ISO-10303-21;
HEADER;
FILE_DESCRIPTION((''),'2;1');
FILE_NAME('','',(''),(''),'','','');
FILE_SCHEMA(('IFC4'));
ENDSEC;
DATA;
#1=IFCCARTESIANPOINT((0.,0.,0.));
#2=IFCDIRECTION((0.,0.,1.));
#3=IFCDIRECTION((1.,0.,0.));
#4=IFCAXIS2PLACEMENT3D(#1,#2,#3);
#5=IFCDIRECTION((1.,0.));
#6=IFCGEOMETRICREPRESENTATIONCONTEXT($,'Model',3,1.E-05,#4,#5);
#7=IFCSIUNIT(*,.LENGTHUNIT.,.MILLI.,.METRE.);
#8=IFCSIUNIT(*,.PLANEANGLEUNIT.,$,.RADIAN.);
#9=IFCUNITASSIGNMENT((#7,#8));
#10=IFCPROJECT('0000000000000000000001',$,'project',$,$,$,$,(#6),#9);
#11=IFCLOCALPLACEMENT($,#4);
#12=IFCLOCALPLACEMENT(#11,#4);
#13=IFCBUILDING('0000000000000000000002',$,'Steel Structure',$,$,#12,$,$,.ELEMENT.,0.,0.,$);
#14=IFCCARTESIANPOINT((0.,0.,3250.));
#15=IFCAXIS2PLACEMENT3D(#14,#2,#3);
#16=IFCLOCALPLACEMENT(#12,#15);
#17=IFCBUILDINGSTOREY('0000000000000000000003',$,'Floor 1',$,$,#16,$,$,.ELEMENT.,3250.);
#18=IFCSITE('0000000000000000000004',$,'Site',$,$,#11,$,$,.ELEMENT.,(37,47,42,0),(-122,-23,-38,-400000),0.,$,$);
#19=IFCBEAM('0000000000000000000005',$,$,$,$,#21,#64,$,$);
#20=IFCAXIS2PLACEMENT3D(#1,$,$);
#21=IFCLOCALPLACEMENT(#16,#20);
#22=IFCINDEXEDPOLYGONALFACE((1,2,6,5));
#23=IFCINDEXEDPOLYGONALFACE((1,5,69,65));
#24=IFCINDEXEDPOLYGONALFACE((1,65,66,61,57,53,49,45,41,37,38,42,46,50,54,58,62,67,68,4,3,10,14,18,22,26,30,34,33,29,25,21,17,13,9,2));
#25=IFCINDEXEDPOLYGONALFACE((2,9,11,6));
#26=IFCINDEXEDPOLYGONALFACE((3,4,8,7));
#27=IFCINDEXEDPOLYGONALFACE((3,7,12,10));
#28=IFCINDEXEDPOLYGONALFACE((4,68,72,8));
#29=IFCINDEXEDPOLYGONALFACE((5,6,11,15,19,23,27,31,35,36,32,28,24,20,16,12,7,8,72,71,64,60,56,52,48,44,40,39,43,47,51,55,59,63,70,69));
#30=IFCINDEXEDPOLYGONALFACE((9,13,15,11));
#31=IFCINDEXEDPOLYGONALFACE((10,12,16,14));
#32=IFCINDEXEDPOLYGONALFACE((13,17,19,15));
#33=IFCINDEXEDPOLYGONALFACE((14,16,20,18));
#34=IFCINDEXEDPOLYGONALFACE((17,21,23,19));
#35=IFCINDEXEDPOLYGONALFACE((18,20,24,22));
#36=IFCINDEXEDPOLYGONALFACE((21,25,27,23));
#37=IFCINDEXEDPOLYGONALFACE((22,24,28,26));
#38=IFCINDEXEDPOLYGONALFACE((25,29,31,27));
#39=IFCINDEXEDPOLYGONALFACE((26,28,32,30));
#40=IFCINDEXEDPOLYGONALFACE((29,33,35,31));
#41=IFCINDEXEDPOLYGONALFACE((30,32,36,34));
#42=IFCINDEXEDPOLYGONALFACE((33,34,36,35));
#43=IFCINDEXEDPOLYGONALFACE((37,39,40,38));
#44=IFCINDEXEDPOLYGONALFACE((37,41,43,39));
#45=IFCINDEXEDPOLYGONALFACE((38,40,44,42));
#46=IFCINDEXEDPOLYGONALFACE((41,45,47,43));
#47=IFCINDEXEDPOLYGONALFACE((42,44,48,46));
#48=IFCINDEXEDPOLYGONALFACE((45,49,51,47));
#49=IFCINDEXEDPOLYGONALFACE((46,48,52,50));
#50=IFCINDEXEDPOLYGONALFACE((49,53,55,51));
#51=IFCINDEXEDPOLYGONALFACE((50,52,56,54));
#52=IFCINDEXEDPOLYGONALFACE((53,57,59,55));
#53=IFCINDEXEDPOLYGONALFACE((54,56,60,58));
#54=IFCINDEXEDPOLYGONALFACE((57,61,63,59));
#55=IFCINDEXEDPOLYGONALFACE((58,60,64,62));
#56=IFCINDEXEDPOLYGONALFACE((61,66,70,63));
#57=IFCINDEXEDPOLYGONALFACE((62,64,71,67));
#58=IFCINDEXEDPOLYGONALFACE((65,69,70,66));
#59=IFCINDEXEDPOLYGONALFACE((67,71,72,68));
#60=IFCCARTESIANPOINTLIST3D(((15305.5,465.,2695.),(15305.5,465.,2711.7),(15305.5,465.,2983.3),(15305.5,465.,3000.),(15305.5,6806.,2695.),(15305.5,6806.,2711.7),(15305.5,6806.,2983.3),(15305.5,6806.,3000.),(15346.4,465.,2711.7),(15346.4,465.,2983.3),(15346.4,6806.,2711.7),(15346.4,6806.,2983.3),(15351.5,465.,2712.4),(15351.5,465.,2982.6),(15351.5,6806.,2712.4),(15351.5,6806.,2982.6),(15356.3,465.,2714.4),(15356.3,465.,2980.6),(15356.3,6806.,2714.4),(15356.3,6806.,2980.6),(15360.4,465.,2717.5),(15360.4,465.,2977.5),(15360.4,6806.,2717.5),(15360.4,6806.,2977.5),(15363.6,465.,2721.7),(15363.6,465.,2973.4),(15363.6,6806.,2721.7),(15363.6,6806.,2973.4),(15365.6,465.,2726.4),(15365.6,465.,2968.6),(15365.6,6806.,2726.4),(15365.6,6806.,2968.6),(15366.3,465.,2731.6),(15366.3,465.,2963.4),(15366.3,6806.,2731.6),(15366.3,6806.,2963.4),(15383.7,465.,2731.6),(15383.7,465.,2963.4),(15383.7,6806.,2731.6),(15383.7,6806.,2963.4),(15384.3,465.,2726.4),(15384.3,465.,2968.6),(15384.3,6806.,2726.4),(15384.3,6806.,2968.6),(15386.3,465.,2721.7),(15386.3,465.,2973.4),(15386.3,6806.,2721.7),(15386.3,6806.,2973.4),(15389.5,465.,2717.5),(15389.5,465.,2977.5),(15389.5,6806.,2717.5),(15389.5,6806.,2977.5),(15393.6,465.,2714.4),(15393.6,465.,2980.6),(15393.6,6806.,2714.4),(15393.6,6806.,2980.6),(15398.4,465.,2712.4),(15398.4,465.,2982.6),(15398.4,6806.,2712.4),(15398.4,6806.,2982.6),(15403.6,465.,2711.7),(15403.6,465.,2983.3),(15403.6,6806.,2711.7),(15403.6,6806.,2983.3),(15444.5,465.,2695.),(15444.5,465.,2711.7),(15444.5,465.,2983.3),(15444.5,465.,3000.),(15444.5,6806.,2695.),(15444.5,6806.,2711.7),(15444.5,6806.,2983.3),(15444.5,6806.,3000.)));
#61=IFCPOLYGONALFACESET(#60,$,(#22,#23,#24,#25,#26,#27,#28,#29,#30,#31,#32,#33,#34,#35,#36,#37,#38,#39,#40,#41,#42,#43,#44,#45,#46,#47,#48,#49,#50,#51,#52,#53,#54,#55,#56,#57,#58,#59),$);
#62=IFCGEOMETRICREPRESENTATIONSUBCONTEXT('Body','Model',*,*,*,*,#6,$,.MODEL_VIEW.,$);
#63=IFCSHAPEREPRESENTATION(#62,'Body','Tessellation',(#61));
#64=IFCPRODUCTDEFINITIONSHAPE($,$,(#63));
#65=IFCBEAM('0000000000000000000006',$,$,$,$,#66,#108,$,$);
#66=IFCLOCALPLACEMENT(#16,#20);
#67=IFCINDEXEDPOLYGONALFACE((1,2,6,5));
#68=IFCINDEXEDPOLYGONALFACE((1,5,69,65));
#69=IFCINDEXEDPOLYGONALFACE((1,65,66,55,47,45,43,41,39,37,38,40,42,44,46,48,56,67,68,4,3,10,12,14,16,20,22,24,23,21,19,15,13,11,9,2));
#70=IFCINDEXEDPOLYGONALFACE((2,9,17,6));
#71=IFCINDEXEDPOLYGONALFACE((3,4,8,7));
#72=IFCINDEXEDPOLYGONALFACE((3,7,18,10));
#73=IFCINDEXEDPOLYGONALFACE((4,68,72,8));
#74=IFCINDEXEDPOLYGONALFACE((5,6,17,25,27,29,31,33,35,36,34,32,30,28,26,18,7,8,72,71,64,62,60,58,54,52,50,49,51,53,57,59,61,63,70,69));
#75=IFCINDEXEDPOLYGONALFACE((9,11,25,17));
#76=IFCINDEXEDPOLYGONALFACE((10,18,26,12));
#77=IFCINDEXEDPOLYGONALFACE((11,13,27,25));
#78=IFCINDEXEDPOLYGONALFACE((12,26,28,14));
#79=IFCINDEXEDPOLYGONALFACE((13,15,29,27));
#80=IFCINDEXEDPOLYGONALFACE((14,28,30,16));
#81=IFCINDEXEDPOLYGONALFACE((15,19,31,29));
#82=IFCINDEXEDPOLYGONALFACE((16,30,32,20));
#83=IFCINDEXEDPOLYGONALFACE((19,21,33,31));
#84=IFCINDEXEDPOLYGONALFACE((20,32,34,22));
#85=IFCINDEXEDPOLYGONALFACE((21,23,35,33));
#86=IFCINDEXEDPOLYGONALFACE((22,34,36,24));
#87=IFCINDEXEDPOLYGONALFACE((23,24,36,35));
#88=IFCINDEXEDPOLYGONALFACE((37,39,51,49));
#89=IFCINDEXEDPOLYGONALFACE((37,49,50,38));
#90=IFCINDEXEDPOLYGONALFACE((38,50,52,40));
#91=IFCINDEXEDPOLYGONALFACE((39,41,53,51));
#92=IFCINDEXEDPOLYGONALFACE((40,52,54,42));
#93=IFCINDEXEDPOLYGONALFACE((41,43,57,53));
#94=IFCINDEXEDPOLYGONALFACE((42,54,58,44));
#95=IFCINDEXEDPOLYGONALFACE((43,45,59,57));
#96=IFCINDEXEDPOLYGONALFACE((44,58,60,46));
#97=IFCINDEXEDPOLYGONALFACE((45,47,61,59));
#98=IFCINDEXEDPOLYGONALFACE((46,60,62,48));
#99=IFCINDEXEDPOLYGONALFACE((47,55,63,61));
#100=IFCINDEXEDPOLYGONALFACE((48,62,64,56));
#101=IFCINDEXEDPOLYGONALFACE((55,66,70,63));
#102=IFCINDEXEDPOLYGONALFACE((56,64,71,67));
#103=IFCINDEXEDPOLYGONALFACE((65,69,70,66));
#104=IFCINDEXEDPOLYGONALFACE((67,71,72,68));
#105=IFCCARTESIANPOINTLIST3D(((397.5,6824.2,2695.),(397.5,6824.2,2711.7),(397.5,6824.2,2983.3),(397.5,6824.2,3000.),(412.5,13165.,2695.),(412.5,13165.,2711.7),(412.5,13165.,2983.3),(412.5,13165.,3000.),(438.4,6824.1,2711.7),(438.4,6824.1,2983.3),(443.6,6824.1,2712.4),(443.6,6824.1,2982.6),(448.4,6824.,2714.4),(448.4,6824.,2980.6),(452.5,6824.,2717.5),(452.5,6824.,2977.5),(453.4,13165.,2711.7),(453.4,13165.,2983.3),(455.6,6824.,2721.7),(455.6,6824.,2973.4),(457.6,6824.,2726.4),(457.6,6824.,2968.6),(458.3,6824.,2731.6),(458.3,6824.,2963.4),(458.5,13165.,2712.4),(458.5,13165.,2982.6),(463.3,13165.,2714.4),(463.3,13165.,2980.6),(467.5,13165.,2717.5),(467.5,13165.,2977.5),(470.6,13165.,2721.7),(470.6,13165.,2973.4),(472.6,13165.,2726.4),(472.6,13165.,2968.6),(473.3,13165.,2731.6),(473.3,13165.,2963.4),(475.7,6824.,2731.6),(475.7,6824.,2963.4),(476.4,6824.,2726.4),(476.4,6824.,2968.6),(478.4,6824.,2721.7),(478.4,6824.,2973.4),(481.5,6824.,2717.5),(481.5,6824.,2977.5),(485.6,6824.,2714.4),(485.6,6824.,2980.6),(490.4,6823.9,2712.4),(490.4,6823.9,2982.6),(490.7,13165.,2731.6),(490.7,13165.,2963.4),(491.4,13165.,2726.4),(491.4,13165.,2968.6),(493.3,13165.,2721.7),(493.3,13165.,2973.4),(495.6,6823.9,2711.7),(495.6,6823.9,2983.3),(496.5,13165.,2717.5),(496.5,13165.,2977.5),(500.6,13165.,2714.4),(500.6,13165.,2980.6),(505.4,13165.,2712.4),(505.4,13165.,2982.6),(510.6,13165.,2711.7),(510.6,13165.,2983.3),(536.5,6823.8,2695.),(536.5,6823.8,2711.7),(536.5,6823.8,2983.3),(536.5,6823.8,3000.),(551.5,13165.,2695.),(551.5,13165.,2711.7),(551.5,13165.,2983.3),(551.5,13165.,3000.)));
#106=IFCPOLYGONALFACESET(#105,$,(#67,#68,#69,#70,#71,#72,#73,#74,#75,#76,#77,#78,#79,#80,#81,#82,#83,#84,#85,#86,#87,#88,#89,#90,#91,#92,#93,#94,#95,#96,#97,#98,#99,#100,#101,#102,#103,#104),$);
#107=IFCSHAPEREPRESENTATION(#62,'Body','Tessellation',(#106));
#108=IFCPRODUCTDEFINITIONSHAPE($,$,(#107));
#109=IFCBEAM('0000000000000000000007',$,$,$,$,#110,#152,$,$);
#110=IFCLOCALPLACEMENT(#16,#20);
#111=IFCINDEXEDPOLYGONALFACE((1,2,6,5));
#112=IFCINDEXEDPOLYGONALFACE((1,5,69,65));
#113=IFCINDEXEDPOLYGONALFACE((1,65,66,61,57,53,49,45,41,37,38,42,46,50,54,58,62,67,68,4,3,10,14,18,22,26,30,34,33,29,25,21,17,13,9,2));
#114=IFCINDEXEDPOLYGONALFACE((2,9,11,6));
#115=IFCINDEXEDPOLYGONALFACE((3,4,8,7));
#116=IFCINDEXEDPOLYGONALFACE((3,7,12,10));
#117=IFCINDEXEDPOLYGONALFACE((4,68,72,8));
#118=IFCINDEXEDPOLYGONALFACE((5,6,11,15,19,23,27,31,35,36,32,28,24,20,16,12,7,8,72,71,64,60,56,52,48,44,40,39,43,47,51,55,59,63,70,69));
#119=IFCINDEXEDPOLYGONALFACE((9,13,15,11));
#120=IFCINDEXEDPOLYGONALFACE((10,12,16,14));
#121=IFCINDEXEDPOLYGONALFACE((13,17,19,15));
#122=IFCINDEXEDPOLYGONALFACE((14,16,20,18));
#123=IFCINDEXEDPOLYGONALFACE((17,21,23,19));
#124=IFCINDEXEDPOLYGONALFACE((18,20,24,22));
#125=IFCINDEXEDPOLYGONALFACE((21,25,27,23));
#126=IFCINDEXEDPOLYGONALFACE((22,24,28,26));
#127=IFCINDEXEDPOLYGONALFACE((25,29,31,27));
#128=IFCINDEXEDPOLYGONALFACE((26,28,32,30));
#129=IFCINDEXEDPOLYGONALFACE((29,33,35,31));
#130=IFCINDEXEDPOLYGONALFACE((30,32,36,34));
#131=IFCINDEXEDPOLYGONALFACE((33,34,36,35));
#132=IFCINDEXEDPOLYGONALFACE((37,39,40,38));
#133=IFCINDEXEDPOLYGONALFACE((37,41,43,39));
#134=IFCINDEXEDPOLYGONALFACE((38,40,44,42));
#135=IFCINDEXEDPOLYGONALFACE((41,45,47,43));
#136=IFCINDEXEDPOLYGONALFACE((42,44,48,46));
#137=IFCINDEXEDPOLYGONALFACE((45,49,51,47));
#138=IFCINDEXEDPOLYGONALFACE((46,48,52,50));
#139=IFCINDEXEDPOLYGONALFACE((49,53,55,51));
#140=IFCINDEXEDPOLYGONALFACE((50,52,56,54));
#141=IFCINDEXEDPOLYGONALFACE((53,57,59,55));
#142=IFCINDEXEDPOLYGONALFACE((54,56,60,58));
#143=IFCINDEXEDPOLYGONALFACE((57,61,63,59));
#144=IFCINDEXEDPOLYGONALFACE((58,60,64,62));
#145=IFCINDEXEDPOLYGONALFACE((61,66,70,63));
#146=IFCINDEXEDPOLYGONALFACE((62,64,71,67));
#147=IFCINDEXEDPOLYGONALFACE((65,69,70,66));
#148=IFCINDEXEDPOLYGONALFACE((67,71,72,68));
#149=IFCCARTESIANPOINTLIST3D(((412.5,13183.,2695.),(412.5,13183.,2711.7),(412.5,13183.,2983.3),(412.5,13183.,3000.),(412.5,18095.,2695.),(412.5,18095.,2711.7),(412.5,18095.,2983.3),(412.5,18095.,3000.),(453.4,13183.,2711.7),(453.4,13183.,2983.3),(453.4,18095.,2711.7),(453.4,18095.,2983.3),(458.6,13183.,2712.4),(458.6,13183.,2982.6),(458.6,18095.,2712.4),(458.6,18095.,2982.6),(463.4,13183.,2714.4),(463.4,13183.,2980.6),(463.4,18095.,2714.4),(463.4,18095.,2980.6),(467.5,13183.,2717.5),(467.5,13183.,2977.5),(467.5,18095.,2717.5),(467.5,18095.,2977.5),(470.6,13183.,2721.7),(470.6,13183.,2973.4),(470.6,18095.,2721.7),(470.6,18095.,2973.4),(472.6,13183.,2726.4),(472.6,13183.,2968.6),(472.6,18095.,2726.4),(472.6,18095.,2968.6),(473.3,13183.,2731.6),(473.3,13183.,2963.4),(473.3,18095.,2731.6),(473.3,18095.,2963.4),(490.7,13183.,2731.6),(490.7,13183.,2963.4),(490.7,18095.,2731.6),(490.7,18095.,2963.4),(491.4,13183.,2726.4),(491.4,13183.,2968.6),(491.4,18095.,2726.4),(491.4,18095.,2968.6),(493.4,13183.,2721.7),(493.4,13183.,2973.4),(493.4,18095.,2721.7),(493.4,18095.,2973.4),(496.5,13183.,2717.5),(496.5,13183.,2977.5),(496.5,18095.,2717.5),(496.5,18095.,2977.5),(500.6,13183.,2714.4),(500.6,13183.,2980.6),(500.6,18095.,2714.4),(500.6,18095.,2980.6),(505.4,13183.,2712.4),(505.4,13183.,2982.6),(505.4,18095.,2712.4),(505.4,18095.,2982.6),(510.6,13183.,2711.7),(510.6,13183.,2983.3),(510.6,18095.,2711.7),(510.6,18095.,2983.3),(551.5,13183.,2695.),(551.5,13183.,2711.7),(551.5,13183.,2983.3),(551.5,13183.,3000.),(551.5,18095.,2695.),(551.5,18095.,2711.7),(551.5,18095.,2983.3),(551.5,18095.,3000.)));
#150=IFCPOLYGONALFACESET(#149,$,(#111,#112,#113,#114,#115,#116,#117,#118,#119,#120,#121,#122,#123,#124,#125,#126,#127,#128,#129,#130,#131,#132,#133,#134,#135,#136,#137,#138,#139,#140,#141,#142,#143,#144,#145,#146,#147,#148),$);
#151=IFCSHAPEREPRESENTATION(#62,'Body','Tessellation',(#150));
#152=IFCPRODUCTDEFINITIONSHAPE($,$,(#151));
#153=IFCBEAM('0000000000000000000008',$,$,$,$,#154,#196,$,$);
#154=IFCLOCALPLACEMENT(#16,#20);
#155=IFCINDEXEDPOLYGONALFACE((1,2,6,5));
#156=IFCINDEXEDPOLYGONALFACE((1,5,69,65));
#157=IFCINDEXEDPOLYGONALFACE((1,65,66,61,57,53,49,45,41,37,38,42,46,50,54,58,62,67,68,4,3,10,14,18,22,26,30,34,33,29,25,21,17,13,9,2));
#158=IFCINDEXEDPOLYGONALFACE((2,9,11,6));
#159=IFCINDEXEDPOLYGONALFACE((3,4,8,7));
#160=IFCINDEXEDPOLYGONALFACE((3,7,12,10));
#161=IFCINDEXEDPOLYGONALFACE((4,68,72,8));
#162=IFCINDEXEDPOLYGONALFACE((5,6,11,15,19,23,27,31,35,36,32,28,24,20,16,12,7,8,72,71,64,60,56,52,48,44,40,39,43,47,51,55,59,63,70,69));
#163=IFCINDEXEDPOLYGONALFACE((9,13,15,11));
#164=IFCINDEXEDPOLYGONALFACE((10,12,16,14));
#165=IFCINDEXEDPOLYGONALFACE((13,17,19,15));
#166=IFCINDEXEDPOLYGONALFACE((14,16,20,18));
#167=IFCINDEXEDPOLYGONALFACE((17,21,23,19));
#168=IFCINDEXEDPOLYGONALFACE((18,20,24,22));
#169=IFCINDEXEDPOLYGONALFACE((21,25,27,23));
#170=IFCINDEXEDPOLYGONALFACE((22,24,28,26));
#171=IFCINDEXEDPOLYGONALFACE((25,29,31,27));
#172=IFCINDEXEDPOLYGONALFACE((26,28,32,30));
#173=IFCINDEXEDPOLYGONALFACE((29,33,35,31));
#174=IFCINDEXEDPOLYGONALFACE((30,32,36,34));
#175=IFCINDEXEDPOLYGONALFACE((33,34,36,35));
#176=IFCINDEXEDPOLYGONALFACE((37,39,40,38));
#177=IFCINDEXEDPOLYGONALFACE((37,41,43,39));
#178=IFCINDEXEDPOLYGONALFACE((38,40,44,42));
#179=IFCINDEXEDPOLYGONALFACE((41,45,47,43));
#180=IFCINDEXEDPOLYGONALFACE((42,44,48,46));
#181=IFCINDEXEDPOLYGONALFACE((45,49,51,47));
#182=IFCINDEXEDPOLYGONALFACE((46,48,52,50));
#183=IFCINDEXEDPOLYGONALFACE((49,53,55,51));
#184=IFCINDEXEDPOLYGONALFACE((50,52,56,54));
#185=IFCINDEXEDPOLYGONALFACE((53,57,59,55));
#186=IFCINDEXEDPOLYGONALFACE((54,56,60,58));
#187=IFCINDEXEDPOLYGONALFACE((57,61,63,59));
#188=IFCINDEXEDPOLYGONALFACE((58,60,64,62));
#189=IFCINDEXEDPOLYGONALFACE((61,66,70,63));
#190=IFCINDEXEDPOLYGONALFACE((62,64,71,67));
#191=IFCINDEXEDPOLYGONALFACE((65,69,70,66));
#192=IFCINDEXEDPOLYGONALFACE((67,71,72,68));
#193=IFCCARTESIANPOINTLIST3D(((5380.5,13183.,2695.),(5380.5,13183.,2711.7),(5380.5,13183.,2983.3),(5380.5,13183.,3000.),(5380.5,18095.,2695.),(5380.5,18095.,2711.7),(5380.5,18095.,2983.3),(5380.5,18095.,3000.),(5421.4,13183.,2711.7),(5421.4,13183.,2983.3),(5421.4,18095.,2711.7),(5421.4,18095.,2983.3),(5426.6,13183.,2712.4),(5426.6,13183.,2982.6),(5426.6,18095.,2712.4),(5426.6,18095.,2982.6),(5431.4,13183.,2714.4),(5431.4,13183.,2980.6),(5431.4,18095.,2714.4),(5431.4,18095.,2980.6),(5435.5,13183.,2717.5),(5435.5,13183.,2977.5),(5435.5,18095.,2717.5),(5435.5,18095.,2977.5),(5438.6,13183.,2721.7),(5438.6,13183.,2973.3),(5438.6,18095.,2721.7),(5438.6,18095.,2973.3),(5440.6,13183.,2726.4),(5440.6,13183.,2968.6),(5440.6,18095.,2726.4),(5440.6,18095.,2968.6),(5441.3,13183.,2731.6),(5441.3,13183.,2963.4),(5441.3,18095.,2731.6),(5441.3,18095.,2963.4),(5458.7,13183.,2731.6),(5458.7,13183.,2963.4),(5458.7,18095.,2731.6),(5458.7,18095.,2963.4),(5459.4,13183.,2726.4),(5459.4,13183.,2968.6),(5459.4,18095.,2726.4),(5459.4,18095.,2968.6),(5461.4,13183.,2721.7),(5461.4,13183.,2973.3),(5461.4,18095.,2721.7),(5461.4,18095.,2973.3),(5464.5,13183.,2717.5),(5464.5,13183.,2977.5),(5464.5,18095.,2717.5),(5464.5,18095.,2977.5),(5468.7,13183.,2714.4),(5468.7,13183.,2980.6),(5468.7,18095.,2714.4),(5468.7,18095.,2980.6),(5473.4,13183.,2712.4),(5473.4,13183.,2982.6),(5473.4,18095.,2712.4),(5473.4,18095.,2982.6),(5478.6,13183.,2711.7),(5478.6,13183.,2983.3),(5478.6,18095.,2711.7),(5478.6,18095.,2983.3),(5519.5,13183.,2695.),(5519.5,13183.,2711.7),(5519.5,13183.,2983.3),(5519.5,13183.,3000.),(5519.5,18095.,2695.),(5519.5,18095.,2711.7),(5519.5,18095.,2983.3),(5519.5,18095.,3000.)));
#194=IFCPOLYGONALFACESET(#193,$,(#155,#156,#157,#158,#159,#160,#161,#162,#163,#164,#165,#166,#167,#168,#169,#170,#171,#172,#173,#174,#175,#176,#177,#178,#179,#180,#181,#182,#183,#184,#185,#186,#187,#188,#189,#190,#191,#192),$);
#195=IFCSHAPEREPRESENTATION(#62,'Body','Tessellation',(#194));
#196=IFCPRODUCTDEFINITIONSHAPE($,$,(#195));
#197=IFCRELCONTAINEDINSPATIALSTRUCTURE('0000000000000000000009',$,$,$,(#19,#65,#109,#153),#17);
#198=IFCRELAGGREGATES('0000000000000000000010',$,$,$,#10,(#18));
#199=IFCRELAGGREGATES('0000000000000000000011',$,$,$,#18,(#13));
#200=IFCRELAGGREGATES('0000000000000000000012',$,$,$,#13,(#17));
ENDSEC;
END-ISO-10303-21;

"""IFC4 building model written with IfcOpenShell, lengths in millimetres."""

from ifc_helpers import new_model, si_unit, direction, frame, origin_with_axes, origin_2d_with_axis, place, context, subcontext, project, spatial, polyline, i_section, extrude, clip, bounded_halfspace, element, save


model = new_model("IFC4")

# Units and contexts
model_context = context("Model", 3, precision=1e-05, world=origin_with_axes(), true_north=direction((1.0, 0.0)))
body_context = subcontext(model_context, "Body", "Model", "MODEL_VIEW")
ifc_project = project(units=[si_unit("LENGTHUNIT", "METRE", prefix="MILLI"), si_unit("PLANEANGLEUNIT", "RADIAN")], contexts=[model_context])

# Site, building, storey
site_placement = place(None, origin_with_axes())
site = spatial("IfcSite", under=ifc_project, at=site_placement, Name="Site", CompositionType="ELEMENT", RefLatitude=(37, 47, 42, 0), RefLongitude=(-122, -23, -38, -400000), RefElevation=0.0)
building_placement = place(site_placement, origin_with_axes())
building = spatial("IfcBuilding", under=site, at=building_placement, Name="Steel Structure", CompositionType="ELEMENT", ElevationOfRefHeight=0.0, ElevationOfTerrain=0.0)
storey_placement = place(building_placement, frame((0.0, 0.0, 3250.0), z_axis=(0.0, 0.0, 1.0), x_axis=(1.0, 0.0, 0.0)))
storey = spatial("IfcBuildingStorey", under=building, at=storey_placement, Name="Floor 1", CompositionType="ELEMENT", Elevation=3250.0)

# Beams
beam_1_placement = place(storey_placement, frame((15375.0, 465.0, 2847.5), z_axis=(0.0, 1.0, 0.0), x_axis=(-1.0, 0.0, 0.0)))
element("IfcBeam", 1, at=beam_1_placement, inside=storey, context=body_context, shape_type="SweptSolid", body=[
    extrude(i_section(OverallWidth=139.0, OverallDepth=305.0, WebThickness=17.4, FlangeThickness=16.7, FilletRadius=19.9, at=origin_2d_with_axis()), origin_with_axes(), (0.0, 0.0, 1.0), 6341.0),
])
beam_2_placement = place(storey_placement, frame((482.0, 13165.2, 2695.0), z_axis=(-0.002362, -0.999997, 0.0), x_axis=(0.999997, -0.002362, 0.0)))
element("IfcBeam", 2, at=beam_2_placement, inside=storey, context=body_context, shape_type="Clipping", body=[
    clip(extrude(i_section(OverallWidth=139.0, OverallDepth=305.0, WebThickness=17.4, FlangeThickness=16.7, FilletRadius=19.9, at=origin_2d_with_axis()), frame((0.0, 152.5, 0.0), z_axis=(0.0, 0.0, 1.0), x_axis=(1.0, 0.0, 0.0)), (0.0, 0.0, 1.0), 6341.2), bounded_halfspace(frame((-482.0, -5945.0, 1.3), z_axis=(-0.002362, 0.0, -0.999997), x_axis=(-0.999997, 0.0, 0.002362)), False, frame((0.0, 152.5, 0.0), z_axis=(0.0, 0.0, 1.0), x_axis=(1.0, 0.0, 0.0)), polyline([(69.5, 152.5), (69.5, 135.8), (28.6, 135.8), (8.7, 115.9), (8.7, -115.9), (28.6, -135.8), (69.5, -135.8), (69.5, -152.5), (-69.5, -152.5), (-69.5, -135.8), (-28.6, -135.8), (-8.7, -115.9), (-8.7, 115.9), (-28.6, 135.8), (-69.5, 135.8), (-69.5, 152.5), (69.5, 152.5)]))),
])
for number, where, z_axis, x_axis in (
    (3, (482.0, 13183.0, 2695.0), (0.0, 1.0, 0.0), (-1.0, 0.0, 0.0)),
    (4, (5450.0, 13183.0, 2695.0), (0.0, 1.0, 0.0), (-1.0, 0.0, 0.0)),
):
    element("IfcBeam", number, at=place(storey_placement, frame(where, z_axis=z_axis, x_axis=x_axis)), inside=storey, context=body_context, shape_type="SweptSolid", body=[
        extrude(i_section(OverallWidth=139.0, OverallDepth=305.0, WebThickness=17.4, FlangeThickness=16.7, FilletRadius=19.9, at=origin_2d_with_axis()), frame((0.0, 152.5, 0.0), z_axis=(0.0, 0.0, 1.0), x_axis=(1.0, 0.0, 0.0)), (0.0, 0.0, 1.0), 4912.0),
    ])

save(model, "model.ifc")
